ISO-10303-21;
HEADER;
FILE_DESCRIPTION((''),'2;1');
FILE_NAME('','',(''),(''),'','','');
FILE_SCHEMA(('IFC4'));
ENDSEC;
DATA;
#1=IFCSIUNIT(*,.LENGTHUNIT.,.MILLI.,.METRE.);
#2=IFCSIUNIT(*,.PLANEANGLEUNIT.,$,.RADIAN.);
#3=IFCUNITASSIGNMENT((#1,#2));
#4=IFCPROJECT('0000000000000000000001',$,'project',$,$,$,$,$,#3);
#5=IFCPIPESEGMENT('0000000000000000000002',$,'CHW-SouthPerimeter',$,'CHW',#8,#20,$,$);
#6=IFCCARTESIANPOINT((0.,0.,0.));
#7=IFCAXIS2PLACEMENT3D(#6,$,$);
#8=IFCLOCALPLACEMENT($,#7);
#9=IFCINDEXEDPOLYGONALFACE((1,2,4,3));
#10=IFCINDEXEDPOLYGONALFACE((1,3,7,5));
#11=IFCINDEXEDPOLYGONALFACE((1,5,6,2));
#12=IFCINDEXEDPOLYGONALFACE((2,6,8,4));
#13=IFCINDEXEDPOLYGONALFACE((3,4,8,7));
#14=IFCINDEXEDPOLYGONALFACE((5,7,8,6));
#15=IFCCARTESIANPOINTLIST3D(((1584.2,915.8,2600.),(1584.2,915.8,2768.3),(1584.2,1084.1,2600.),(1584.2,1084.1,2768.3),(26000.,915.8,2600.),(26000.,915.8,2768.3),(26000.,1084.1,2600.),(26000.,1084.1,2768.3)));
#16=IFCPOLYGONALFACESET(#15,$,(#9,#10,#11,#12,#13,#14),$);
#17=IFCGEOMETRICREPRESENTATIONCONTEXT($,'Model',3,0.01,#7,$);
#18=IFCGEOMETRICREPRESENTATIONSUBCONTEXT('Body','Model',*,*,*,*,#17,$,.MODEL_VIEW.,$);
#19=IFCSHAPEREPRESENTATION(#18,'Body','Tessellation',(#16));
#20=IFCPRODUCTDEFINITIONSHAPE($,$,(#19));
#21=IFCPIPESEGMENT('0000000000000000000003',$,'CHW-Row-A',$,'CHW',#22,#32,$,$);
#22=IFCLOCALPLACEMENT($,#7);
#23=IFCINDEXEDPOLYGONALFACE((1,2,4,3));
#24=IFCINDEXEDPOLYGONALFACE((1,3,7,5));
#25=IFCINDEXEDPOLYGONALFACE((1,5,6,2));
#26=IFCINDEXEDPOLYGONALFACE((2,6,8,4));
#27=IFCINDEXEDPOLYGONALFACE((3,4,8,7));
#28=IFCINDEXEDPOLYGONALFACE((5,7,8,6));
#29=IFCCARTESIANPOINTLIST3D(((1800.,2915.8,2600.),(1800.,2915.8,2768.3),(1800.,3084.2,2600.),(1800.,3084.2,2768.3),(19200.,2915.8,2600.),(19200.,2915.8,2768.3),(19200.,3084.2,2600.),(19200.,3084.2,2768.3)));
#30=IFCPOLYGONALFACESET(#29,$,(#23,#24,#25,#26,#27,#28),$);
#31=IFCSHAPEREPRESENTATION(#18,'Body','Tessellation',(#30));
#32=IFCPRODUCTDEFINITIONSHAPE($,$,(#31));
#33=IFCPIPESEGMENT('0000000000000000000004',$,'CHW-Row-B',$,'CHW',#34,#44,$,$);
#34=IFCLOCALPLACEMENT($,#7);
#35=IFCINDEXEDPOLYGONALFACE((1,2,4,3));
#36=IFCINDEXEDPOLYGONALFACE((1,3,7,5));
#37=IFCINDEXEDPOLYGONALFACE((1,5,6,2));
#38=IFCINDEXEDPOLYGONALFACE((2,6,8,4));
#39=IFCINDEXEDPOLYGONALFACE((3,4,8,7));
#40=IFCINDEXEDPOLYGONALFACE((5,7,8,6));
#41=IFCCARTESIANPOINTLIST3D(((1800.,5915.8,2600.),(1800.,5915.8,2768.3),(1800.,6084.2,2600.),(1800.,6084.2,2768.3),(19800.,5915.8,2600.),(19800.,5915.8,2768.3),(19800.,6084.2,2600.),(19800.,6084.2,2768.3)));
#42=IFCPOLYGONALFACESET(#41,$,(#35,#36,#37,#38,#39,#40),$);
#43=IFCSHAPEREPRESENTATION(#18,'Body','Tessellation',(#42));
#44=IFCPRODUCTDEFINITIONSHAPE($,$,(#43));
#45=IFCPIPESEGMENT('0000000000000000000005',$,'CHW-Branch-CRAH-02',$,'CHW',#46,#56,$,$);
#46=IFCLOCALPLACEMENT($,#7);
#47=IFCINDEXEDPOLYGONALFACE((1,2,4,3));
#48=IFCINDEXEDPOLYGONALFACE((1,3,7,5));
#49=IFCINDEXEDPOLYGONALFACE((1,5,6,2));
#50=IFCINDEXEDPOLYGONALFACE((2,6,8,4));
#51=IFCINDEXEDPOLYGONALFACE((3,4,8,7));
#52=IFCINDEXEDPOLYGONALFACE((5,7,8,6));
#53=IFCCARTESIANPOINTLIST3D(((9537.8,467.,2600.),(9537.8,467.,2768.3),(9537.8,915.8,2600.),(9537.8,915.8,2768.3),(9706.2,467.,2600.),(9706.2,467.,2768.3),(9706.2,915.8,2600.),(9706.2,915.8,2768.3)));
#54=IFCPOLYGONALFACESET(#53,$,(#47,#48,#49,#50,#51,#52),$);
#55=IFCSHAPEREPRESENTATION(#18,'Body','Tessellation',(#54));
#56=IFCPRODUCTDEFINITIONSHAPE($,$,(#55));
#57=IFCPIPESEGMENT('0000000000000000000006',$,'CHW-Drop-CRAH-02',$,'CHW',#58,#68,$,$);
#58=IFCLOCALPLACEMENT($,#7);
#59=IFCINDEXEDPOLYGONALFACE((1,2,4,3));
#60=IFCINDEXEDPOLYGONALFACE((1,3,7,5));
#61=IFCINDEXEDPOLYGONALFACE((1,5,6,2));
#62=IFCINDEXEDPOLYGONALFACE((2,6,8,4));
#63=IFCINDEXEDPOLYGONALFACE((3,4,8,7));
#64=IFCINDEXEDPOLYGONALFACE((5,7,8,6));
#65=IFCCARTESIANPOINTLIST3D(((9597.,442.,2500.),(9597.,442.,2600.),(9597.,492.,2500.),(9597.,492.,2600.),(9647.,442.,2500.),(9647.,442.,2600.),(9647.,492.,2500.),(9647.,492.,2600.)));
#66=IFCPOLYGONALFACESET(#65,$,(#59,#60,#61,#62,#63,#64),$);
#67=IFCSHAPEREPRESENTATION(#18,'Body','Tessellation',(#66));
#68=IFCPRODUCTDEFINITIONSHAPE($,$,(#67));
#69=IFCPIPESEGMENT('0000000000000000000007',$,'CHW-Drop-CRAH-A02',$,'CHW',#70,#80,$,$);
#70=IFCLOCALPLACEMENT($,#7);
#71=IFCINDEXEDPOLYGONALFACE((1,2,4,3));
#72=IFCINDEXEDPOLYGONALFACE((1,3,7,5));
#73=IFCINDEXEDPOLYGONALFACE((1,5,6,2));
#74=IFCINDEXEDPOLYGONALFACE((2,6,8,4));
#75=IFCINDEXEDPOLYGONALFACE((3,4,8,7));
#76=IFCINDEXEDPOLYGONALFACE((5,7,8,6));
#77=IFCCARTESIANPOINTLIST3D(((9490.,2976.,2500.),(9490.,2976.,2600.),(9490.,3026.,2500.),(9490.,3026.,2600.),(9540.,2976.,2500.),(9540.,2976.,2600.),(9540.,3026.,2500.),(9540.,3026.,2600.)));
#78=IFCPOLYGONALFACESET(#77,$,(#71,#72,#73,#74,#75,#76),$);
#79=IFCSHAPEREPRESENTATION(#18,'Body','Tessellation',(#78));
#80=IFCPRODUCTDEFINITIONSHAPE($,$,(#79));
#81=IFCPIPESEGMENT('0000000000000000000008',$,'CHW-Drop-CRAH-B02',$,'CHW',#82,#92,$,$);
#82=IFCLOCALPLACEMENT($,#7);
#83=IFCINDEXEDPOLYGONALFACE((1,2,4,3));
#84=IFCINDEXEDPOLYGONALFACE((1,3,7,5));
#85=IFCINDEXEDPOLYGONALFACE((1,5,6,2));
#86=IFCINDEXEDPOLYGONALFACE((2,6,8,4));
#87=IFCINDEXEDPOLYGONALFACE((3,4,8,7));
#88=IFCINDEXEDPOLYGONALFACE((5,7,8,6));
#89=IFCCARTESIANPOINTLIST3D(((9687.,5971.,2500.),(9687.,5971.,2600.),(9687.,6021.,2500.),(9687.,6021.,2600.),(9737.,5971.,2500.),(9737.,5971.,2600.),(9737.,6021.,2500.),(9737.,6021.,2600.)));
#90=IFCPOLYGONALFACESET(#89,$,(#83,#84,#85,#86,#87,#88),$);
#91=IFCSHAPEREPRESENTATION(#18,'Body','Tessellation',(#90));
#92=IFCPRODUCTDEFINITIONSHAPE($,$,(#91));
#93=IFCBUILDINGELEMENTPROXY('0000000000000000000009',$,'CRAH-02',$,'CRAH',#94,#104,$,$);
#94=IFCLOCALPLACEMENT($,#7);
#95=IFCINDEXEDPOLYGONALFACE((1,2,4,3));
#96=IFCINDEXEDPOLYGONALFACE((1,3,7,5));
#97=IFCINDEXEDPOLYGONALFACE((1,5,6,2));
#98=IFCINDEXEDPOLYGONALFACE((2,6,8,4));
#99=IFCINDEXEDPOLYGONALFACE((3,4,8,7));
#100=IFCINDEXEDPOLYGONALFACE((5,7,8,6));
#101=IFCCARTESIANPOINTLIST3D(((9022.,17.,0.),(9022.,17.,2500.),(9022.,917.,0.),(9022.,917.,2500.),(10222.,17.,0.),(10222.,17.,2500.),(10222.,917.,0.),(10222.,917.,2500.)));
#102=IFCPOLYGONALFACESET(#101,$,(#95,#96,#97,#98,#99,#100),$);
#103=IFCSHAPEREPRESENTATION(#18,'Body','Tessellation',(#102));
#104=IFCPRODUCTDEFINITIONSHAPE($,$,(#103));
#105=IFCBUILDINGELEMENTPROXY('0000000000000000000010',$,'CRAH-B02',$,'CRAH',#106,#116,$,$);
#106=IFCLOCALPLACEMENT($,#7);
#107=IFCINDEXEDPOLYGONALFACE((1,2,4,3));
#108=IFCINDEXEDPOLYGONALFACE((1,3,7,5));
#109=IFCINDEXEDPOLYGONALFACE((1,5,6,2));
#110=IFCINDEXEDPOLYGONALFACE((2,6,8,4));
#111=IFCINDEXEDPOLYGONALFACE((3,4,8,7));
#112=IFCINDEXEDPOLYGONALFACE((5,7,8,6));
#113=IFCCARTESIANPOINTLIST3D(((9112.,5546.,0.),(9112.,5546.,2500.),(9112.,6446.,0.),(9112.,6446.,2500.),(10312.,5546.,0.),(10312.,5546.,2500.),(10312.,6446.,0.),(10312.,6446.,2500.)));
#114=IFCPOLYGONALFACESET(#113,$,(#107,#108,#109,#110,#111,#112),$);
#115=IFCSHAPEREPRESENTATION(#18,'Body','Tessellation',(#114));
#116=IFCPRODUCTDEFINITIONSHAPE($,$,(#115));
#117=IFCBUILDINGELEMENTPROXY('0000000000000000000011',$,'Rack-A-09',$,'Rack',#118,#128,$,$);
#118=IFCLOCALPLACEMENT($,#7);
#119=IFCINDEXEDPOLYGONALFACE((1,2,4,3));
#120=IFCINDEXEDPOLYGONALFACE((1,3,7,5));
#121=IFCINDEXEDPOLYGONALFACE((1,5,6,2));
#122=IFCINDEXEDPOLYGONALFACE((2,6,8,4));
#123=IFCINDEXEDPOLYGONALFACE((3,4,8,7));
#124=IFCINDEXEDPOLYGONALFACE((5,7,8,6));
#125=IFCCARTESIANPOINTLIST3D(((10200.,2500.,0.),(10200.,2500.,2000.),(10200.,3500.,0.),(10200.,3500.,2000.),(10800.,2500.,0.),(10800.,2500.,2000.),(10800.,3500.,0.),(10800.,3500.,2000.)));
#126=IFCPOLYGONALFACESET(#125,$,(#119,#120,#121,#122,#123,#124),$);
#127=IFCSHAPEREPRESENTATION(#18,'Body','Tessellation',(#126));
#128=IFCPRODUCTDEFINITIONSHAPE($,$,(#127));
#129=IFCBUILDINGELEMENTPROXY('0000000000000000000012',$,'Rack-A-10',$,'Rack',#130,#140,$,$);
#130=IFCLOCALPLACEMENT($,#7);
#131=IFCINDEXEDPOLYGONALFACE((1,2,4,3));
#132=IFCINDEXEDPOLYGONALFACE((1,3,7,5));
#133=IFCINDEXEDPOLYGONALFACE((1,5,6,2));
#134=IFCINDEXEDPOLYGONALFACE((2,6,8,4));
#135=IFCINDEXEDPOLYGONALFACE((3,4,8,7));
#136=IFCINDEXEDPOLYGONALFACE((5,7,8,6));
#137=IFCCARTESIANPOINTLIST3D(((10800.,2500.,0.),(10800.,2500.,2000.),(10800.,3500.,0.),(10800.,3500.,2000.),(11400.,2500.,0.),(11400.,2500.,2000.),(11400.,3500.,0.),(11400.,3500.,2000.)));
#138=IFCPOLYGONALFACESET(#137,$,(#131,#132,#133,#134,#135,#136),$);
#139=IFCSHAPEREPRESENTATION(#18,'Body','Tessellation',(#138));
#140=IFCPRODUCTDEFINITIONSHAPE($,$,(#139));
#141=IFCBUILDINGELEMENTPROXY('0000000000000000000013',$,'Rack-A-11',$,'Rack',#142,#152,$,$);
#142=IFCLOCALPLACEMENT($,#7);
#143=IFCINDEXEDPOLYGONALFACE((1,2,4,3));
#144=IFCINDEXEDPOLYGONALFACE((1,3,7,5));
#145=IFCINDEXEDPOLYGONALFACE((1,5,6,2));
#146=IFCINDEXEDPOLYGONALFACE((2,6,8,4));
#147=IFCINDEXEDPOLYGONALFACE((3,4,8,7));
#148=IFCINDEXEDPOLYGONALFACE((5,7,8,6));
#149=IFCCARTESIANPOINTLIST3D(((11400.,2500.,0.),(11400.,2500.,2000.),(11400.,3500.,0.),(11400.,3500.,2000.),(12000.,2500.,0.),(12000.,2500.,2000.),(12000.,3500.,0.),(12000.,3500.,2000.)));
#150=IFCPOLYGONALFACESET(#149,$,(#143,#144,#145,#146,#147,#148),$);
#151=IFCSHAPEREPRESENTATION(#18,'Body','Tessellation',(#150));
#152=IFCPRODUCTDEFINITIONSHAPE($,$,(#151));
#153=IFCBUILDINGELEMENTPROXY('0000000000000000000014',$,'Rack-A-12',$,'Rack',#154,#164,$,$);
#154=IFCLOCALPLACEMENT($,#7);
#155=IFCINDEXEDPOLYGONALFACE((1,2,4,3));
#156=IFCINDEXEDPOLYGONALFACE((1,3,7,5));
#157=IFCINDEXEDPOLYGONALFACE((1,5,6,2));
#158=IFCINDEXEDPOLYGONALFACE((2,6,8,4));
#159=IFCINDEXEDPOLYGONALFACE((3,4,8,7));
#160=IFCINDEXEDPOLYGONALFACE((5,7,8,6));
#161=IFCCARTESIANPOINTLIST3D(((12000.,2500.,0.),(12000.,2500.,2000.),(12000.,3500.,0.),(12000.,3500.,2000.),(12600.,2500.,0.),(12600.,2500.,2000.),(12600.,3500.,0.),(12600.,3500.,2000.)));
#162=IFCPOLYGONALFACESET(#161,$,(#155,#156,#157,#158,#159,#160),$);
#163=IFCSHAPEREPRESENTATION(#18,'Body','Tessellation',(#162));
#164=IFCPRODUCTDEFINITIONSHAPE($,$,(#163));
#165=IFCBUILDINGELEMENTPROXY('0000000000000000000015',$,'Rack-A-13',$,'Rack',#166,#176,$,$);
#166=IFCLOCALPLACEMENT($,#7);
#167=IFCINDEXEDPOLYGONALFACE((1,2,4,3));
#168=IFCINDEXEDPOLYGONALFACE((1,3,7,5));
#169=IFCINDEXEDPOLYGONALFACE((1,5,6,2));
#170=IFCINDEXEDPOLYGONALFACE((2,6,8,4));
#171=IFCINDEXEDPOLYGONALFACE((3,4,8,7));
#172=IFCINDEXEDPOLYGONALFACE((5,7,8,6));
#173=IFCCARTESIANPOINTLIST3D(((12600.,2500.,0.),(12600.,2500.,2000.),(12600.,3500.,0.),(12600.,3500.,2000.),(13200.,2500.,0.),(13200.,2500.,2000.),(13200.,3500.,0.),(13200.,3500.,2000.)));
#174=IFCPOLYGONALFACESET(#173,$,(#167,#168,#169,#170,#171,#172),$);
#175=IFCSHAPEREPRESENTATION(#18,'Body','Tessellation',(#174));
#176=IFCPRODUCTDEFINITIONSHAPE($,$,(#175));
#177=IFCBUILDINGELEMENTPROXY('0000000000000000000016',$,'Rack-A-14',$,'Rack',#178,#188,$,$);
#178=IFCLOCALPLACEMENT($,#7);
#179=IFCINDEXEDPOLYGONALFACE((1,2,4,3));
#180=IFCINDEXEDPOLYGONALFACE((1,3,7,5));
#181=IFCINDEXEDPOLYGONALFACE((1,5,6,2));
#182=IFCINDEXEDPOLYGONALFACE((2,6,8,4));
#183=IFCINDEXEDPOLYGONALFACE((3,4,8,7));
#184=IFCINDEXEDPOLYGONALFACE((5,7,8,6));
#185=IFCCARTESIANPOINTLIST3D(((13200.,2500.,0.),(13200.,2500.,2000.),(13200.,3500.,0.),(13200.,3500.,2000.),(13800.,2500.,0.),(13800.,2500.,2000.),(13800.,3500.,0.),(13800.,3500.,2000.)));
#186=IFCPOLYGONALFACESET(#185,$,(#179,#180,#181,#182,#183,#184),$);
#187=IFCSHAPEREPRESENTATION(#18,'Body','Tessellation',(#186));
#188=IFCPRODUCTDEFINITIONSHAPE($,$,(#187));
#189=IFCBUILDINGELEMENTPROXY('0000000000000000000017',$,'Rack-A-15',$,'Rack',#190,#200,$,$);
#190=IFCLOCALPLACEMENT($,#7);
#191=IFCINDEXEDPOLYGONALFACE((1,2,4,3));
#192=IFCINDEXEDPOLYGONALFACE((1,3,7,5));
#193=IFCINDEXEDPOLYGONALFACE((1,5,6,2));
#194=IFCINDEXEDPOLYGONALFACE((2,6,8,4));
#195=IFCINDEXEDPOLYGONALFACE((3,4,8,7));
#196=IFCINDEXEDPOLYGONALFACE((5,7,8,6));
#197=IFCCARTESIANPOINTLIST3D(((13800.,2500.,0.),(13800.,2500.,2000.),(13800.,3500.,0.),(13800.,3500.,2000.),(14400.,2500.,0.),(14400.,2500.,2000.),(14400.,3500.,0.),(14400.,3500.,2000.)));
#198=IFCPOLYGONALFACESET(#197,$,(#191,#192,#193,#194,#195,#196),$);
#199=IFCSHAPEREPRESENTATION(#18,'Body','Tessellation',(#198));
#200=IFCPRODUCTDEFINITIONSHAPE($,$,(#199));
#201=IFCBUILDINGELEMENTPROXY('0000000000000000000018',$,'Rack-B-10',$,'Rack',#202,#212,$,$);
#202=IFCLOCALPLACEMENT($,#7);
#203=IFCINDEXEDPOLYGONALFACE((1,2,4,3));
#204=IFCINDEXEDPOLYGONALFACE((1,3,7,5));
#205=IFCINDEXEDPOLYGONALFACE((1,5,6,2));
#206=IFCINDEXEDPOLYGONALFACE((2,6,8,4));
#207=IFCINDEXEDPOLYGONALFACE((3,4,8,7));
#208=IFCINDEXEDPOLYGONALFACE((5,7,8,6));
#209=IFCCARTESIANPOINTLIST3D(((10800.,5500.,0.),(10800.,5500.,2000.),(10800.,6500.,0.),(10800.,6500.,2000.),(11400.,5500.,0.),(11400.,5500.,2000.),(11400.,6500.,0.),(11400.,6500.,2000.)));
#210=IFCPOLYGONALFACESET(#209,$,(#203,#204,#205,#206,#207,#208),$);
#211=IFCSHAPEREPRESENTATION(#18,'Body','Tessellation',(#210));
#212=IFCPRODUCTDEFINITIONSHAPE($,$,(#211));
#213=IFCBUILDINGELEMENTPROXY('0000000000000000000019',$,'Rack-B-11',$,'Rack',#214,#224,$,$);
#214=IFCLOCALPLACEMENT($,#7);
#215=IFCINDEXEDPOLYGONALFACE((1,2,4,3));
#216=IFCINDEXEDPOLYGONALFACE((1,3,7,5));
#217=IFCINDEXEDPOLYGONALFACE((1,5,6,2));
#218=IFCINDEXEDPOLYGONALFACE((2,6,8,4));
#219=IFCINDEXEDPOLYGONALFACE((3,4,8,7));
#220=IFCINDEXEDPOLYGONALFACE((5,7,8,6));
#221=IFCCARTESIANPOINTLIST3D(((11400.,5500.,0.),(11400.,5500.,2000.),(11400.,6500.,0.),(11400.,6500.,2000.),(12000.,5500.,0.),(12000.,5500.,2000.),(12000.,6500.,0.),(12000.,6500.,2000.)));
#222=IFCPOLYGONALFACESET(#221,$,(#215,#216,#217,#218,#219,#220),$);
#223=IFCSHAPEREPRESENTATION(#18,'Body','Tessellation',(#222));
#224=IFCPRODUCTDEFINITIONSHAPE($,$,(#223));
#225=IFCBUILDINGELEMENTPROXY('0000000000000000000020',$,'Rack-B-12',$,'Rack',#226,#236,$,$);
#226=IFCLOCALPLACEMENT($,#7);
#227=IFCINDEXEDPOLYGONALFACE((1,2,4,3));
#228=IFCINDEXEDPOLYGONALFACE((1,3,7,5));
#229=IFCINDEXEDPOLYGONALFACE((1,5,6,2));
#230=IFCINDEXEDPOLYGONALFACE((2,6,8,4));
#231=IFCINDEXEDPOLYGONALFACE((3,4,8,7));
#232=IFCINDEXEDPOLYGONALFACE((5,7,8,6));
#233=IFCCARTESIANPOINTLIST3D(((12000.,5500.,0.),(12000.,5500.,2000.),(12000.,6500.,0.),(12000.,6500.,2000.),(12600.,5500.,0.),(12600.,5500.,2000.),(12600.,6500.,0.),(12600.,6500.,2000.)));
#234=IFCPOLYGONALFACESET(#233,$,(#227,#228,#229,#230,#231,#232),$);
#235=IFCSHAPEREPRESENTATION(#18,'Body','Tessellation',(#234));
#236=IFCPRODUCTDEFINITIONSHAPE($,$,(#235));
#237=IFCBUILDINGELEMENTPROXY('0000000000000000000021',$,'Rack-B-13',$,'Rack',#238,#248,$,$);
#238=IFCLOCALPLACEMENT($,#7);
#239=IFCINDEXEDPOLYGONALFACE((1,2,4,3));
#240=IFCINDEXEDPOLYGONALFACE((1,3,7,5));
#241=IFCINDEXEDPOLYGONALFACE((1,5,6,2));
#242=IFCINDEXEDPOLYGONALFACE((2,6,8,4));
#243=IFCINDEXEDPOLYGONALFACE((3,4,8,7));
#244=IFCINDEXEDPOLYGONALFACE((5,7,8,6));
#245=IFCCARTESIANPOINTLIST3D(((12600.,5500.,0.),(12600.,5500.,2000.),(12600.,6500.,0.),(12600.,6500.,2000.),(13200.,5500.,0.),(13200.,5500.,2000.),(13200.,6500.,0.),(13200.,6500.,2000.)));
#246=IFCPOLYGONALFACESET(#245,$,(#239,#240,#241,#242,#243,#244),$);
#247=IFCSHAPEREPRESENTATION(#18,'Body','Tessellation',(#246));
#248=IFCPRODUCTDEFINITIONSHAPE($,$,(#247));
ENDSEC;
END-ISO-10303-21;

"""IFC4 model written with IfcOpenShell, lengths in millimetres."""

from ifc_helpers import new_model, si_unit, frame, origin, place, context, subcontext, project, rectangle, extrude, element, save


model = new_model("IFC4")

# Units and contexts
model_context = context("Model", 3, precision=0.01, world=origin())
body_context = subcontext(model_context, "Body", "Model", "MODEL_VIEW")
ifc_project = project(units=[si_unit("LENGTHUNIT", "METRE", prefix="MILLI"), si_unit("PLANEANGLEUNIT", "RADIAN")])

# Pipe segments
placement = place(None, origin())
pipe_segment_1_placement = place(placement, frame((13792.1, 1000.0, 2600.0)))
element("IfcPipeSegment", 1, at=pipe_segment_1_placement, Name="CHW-SouthPerimeter", ObjectType="CHW", context=body_context, shape_type="SweptSolid", body=[
    extrude(rectangle(XDim=24415.8, YDim=168.3), origin(), (0.0, 0.0, 1.0), 168.3),
])
pipe_segment_2_placement = place(placement, frame((10500.0, 3000.0, 2600.0)))
element("IfcPipeSegment", 2, at=pipe_segment_2_placement, Name="CHW-Row-A", ObjectType="CHW", context=body_context, shape_type="SweptSolid", body=[
    extrude(rectangle(XDim=17400.0, YDim=168.3), origin(), (0.0, 0.0, 1.0), 168.3),
])
pipe_segment_3_placement = place(placement, frame((10800.0, 6000.0, 2600.0)))
element("IfcPipeSegment", 3, at=pipe_segment_3_placement, Name="CHW-Row-B", ObjectType="CHW", context=body_context, shape_type="SweptSolid", body=[
    extrude(rectangle(XDim=18000.0, YDim=168.3), origin(), (0.0, 0.0, 1.0), 168.3),
])
pipe_segment_4_placement = place(placement, frame((9622.0, 691.4, 2600.0)))
element("IfcPipeSegment", 4, at=pipe_segment_4_placement, Name="CHW-Branch-CRAH-02", ObjectType="CHW", context=body_context, shape_type="SweptSolid", body=[
    extrude(rectangle(XDim=168.3, YDim=448.9), origin(), (0.0, 0.0, 1.0), 168.3),
])
for number, where, name in (
    (5, (9622.0, 467.0, 2500.0), "CHW-Drop-CRAH-02"),
    (6, (9515.0, 3001.0, 2500.0), "CHW-Drop-CRAH-A02"),
    (7, (9712.0, 5996.0, 2500.0), "CHW-Drop-CRAH-B02"),
):
    element("IfcPipeSegment", number, at=place(placement, frame(where)), Name=name, ObjectType="CHW", context=body_context, shape_type="SweptSolid", body=[
        extrude(rectangle(XDim=50.0, YDim=50.0), origin(), (0.0, 0.0, 1.0), 100.0),
    ])

# Building element proxies
for number, where, name in (
    (8, (9622.0, 467.0, 0.0), "CRAH-02"),
    (9, (9712.0, 5996.0, 0.0), "CRAH-B02"),
):
    element("IfcBuildingElementProxy", number, at=place(placement, frame(where)), Name=name, ObjectType="CRAH", context=body_context, shape_type="SweptSolid", body=[
        extrude(rectangle(XDim=1200.0, YDim=900.0), origin(), (0.0, 0.0, 1.0), 2500.0),
    ])
for number, where, name in (
    (10, (10500.0, 3000.0, 0.0), "Rack-A-09"),
    (11, (11100.0, 3000.0, 0.0), "Rack-A-10"),
    (12, (11700.0, 3000.0, 0.0), "Rack-A-11"),
    (13, (12300.0, 3000.0, 0.0), "Rack-A-12"),
    (14, (12900.0, 3000.0, 0.0), "Rack-A-13"),
    (15, (13500.0, 3000.0, 0.0), "Rack-A-14"),
    (16, (14100.0, 3000.0, 0.0), "Rack-A-15"),
    (17, (11100.0, 6000.0, 0.0), "Rack-B-10"),
    (18, (11700.0, 6000.0, 0.0), "Rack-B-11"),
    (19, (12300.0, 6000.0, 0.0), "Rack-B-12"),
    (20, (12900.0, 6000.0, 0.0), "Rack-B-13"),
):
    element("IfcBuildingElementProxy", number, at=place(placement, frame(where)), Name=name, ObjectType="Rack", context=body_context, shape_type="SweptSolid", body=[
        extrude(rectangle(XDim=600.0, YDim=1000.0), origin(), (0.0, 0.0, 1.0), 2000.0),
    ])

save(model, "model.ifc")
